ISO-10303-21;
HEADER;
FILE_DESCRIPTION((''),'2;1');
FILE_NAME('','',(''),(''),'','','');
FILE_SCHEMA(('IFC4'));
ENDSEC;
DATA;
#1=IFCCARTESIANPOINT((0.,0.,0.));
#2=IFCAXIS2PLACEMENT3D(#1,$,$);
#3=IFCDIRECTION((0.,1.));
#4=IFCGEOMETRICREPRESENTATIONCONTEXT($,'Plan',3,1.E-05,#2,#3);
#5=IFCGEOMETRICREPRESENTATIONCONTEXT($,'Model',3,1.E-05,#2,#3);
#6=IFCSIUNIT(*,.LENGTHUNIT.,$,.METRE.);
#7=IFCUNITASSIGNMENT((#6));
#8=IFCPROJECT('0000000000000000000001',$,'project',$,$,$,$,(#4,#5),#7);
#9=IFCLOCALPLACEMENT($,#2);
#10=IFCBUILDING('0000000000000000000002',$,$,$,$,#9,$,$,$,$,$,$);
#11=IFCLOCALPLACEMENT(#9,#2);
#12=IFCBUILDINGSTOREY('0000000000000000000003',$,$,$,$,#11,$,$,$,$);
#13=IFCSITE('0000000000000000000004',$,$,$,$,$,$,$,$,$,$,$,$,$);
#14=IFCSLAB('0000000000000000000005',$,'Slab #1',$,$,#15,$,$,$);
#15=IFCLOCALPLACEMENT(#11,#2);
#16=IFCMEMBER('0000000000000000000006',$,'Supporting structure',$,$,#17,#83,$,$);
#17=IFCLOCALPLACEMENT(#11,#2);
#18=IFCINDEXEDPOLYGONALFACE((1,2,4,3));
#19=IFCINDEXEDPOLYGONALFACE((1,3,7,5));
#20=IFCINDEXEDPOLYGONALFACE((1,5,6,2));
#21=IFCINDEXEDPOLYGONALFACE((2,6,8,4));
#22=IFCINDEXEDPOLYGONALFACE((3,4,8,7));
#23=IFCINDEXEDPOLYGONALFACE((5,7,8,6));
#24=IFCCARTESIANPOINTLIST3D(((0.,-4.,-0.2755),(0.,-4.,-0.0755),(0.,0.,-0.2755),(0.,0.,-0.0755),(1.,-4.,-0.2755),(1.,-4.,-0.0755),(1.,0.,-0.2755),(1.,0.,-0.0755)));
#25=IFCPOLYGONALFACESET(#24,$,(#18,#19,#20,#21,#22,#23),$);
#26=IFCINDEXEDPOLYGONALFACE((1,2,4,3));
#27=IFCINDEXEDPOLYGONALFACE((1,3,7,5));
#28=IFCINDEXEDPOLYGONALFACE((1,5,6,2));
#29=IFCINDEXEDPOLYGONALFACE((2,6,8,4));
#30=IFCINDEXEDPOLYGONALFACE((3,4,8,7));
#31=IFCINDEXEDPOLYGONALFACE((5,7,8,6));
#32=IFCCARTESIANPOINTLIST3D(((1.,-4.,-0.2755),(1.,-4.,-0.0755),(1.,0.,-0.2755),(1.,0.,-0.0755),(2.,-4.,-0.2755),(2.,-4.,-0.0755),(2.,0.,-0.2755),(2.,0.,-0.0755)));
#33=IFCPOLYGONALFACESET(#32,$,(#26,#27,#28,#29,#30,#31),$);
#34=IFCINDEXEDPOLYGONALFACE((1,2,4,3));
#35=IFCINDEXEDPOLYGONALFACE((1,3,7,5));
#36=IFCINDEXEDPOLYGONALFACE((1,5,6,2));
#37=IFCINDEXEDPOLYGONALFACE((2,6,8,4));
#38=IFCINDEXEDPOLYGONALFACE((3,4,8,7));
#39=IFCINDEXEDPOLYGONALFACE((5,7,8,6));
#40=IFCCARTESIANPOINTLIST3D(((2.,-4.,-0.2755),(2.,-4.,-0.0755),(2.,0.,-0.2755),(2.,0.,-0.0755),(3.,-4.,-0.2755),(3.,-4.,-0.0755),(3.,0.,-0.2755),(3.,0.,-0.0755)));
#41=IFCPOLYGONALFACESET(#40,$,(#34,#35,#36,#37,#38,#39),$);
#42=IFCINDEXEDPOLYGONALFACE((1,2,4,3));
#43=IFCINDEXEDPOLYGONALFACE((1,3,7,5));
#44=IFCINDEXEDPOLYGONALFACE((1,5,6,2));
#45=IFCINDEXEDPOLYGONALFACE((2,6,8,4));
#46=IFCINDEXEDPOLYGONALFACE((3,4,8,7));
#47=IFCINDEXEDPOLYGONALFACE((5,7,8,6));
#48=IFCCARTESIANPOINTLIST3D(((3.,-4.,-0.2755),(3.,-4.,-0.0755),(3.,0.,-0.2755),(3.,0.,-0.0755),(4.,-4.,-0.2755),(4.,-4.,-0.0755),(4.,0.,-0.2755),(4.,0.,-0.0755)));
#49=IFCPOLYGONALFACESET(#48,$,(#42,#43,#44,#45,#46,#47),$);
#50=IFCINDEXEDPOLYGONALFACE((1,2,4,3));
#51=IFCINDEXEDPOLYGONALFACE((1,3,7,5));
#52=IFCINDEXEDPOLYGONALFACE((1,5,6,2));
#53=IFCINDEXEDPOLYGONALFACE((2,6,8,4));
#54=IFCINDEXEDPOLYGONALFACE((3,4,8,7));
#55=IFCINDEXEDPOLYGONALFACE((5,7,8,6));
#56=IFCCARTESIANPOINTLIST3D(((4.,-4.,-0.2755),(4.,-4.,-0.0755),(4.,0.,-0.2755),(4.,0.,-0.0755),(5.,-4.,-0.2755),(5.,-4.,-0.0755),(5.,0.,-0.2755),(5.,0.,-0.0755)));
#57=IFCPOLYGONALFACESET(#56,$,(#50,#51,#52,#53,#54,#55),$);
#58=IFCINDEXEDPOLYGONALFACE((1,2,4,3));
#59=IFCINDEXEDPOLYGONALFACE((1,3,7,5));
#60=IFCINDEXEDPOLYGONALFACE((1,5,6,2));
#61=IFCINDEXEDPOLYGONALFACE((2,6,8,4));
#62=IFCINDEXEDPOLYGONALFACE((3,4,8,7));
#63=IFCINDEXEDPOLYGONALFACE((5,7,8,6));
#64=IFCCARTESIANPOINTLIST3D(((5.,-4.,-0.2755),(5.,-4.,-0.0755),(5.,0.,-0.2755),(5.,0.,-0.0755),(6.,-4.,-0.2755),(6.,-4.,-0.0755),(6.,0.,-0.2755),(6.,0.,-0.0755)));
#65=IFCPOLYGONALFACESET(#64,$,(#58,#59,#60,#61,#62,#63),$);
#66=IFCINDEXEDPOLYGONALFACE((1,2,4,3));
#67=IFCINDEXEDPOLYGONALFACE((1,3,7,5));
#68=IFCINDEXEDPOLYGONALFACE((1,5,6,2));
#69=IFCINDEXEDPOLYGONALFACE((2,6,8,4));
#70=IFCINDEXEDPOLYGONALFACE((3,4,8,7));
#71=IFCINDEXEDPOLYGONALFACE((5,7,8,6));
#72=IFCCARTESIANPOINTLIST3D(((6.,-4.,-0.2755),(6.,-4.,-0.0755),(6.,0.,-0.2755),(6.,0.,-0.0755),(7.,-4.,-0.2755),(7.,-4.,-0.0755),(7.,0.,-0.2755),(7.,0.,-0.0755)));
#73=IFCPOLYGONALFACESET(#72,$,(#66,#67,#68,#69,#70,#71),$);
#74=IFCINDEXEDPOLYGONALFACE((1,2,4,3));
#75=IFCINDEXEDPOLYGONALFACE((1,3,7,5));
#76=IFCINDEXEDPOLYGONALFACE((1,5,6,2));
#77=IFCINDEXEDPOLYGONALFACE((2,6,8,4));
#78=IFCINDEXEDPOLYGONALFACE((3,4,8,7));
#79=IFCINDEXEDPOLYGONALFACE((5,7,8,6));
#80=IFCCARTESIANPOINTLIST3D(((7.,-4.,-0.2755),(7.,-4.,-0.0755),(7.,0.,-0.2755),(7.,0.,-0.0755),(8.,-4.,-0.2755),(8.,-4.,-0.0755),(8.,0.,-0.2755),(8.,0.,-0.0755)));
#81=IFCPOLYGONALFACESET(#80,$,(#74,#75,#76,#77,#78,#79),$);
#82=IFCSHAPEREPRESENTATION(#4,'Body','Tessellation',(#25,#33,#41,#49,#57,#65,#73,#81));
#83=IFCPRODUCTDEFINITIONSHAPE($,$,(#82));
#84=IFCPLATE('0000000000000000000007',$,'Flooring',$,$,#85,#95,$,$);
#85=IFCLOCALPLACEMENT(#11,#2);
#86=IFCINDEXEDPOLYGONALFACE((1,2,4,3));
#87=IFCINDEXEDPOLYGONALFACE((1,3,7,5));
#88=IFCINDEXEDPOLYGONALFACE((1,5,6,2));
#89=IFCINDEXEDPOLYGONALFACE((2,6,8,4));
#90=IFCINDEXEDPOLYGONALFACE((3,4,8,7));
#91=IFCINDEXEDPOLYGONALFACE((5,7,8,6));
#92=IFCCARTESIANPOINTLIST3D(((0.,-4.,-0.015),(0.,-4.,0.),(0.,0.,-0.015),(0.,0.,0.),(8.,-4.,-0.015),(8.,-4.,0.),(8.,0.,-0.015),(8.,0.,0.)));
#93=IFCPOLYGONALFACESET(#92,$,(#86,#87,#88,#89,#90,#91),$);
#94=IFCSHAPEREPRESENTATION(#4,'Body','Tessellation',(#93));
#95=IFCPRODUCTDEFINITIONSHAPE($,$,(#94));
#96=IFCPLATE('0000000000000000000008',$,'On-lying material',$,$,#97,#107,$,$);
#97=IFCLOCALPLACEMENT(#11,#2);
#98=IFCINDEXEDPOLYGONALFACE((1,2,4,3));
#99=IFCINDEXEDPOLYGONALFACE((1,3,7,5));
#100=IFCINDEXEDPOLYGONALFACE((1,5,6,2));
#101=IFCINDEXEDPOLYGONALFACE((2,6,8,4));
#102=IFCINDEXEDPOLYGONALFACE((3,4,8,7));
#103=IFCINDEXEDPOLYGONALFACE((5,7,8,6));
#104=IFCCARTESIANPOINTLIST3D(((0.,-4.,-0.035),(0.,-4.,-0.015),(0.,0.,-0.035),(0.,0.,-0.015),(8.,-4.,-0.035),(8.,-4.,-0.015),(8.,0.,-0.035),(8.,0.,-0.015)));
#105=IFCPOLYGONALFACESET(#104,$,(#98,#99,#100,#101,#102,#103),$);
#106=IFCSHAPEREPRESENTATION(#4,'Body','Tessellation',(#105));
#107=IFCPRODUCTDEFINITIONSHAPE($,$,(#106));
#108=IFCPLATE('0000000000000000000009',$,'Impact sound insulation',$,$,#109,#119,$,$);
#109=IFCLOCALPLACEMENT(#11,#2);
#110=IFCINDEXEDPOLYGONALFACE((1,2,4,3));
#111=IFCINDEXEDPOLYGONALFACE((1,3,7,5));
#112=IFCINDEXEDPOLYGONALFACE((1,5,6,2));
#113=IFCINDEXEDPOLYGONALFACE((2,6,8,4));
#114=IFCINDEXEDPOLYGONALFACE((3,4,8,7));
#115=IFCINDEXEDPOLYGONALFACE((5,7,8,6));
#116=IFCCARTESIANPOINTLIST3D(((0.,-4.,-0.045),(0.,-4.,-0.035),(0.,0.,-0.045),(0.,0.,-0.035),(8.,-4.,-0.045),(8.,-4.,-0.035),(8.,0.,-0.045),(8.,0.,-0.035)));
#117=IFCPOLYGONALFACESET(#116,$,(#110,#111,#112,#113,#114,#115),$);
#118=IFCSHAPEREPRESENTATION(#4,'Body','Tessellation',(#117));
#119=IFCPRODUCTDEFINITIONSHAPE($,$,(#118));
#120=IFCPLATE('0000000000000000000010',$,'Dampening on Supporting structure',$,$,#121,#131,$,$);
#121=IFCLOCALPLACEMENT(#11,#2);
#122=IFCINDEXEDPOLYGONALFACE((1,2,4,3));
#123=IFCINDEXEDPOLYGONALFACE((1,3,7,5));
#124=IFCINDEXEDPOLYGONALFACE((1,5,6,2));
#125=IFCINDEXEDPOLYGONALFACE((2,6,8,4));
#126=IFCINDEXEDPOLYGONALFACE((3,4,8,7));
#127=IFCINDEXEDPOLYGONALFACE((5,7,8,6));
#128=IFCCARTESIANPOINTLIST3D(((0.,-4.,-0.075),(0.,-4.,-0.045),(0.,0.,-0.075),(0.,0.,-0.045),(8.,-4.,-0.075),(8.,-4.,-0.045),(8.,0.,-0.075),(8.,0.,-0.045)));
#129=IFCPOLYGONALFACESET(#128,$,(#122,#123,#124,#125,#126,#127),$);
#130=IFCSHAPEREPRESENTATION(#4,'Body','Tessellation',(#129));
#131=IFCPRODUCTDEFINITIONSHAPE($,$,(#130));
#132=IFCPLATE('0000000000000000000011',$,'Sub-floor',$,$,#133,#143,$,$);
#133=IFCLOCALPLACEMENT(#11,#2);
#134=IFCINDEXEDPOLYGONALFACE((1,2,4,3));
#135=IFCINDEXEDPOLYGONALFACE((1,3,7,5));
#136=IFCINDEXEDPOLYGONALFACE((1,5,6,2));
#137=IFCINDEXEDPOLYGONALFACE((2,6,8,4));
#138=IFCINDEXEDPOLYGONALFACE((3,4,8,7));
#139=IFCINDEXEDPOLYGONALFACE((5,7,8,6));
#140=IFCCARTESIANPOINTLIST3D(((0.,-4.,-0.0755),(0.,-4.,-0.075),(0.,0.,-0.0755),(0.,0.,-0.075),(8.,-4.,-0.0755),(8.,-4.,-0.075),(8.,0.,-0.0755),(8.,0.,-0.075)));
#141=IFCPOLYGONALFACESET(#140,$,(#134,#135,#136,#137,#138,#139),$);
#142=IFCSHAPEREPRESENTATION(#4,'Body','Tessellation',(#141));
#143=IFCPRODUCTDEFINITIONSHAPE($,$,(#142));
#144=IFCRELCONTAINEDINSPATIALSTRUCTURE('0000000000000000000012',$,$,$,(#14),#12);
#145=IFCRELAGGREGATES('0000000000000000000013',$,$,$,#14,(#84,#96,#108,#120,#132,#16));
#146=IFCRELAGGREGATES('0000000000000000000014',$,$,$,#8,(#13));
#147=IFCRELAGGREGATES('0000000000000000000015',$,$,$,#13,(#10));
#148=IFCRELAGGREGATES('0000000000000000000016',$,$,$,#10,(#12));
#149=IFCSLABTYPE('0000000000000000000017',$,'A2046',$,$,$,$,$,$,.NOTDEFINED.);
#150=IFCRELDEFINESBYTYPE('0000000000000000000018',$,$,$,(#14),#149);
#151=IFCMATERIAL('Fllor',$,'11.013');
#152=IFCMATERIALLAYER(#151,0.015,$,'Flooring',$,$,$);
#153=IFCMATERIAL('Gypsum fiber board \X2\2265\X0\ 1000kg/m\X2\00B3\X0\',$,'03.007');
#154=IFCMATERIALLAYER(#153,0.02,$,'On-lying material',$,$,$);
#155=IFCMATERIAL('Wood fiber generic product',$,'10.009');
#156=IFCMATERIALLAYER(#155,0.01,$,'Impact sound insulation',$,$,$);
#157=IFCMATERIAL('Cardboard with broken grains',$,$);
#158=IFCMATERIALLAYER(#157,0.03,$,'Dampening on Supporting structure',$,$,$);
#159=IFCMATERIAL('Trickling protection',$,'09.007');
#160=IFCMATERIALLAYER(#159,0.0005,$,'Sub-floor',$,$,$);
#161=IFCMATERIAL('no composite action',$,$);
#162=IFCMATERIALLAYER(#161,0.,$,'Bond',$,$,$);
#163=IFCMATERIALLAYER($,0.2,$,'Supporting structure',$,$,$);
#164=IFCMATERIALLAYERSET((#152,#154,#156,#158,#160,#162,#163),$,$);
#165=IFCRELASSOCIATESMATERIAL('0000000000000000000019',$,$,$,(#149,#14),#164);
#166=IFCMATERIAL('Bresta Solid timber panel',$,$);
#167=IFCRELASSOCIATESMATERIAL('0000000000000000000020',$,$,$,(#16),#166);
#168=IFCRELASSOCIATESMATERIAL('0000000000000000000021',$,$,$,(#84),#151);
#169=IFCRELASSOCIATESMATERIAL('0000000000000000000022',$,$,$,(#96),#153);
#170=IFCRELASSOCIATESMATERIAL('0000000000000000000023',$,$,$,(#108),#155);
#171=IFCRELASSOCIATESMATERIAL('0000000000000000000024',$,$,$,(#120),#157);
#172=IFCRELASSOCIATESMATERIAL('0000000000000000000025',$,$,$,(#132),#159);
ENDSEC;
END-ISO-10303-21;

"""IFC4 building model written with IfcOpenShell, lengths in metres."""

from ifc_helpers import new_model, si_unit, direction, frame, frame_2d, origin, origin_with_axes, place, context, project, spatial, rectangle, extrude, material, layer, layer_set, type_object, element, aggregate, save


model = new_model("IFC4")

# Units and contexts
plan_context = context("Plan", 3, precision=1e-05, world=origin(), true_north=direction((0.0, 1.0)))
model_context = context("Model", 3, precision=1e-05, world=origin(), true_north=direction((0.0, 1.0)))
ifc_project = project(units=[si_unit("LENGTHUNIT", "METRE")], contexts=[plan_context, model_context])

# Site, building, storey
site = spatial("IfcSite", under=ifc_project)
building_placement = place(None, origin())
building = spatial("IfcBuilding", under=site, at=building_placement)
storey_placement = place(building_placement, origin())
storey = spatial("IfcBuildingStorey", under=building, at=storey_placement)

# Slab, member, plates
ifc_material_1 = material(Name="Fllor", Category="11.013")
ifc_layer_1 = layer(ifc_material_1, 0.015, Name="Flooring")
ifc_material_2 = material(Name="Gypsum fiber board ≥ 1000kg/m³", Category="03.007")
ifc_layer_2 = layer(ifc_material_2, 0.02, Name="On-lying material")
ifc_material_3 = material(Name="Wood fiber generic product", Category="10.009")
ifc_layer_3 = layer(ifc_material_3, 0.01, Name="Impact sound insulation")
ifc_material_4 = material(Name="Cardboard with broken grains")
ifc_layer_4 = layer(ifc_material_4, 0.03, Name="Dampening on Supporting structure")
ifc_material_5 = material(Name="Trickling protection", Category="09.007")
ifc_layer_5 = layer(ifc_material_5, 0.0005, Name="Sub-floor")
ifc_material_6 = material(Name="no composite action")
ifc_layer_6 = layer(ifc_material_6, 0.0, Name="Bond")
ifc_layer_7 = layer(None, 0.2, Name="Supporting structure")
ifc_layer_set = layer_set([ifc_layer_1, ifc_layer_2, ifc_layer_3, ifc_layer_4, ifc_layer_5, ifc_layer_6, ifc_layer_7])
slab_type = type_object("IfcSlabType", Name="A2046", PredefinedType="NOTDEFINED", material=ifc_layer_set)
slab_placement = place(None, frame((0.0, 0.0, 0.0), z_axis=(0.0, 0.0, -1.0), x_axis=(1.0, 0.0, 0.0)))
slab = element("IfcSlab", 1, at=slab_placement, inside=storey, type_object=slab_type, material=ifc_layer_set, Name="Slab #1")
ifc_material_7 = material(Name="Bresta Solid timber panel")
member_placement = place(slab_placement, origin())
member = element("IfcMember", 2, at=member_placement, material=ifc_material_7, Name="Supporting structure", context=plan_context, shape_type="SweptSolid", body=[
    extrude(rectangle(XDim=1.0, YDim=0.2, at=frame_2d((0.5, 0.1), x_axis=(1.0, 0.0))), frame((0.0, 4.0, 0.0755), z_axis=(0.0, -1.0, 0.0), x_axis=(1.0, 0.0, 0.0)), (0.0, 0.0, 1.0), 4.0),
    extrude(rectangle(XDim=1.0, YDim=0.2, at=frame_2d((0.5, 0.1), x_axis=(1.0, 0.0))), frame((1.0, 4.0, 0.0755), z_axis=(0.0, -1.0, 0.0), x_axis=(1.0, 0.0, 0.0)), (0.0, 0.0, 1.0), 4.0),
    extrude(rectangle(XDim=1.0, YDim=0.2, at=frame_2d((0.5, 0.1), x_axis=(1.0, 0.0))), frame((2.0, 4.0, 0.0755), z_axis=(0.0, -1.0, 0.0), x_axis=(1.0, 0.0, 0.0)), (0.0, 0.0, 1.0), 4.0),
    extrude(rectangle(XDim=1.0, YDim=0.2, at=frame_2d((0.5, 0.1), x_axis=(1.0, 0.0))), frame((3.0, 4.0, 0.0755), z_axis=(0.0, -1.0, 0.0), x_axis=(1.0, 0.0, 0.0)), (0.0, 0.0, 1.0), 4.0),
    extrude(rectangle(XDim=1.0, YDim=0.2, at=frame_2d((0.5, 0.1), x_axis=(1.0, 0.0))), frame((4.0, 4.0, 0.0755), z_axis=(0.0, -1.0, 0.0), x_axis=(1.0, 0.0, 0.0)), (0.0, 0.0, 1.0), 4.0),
    extrude(rectangle(XDim=1.0, YDim=0.2, at=frame_2d((0.5, 0.1), x_axis=(1.0, 0.0))), frame((5.0, 4.0, 0.0755), z_axis=(0.0, -1.0, 0.0), x_axis=(1.0, 0.0, 0.0)), (0.0, 0.0, 1.0), 4.0),
    extrude(rectangle(XDim=1.0, YDim=0.2, at=frame_2d((0.5, 0.1), x_axis=(1.0, 0.0))), frame((6.0, 4.0, 0.0755), z_axis=(0.0, -1.0, 0.0), x_axis=(1.0, 0.0, 0.0)), (0.0, 0.0, 1.0), 4.0),
    extrude(rectangle(XDim=1.0, YDim=0.2, at=frame_2d((0.5, 0.1), x_axis=(1.0, 0.0))), frame((7.0, 4.0, 0.0755), z_axis=(0.0, -1.0, 0.0), x_axis=(1.0, 0.0, 0.0)), (0.0, 0.0, 1.0), 4.0),
])
plate_1_placement = place(slab_placement, origin())
plate_1 = element("IfcPlate", 3, at=plate_1_placement, material=ifc_material_1, Name="Flooring", context=plan_context, shape_type="SweptSolid", body=[
    extrude(rectangle(XDim=8.0, YDim=4.0, at=frame_2d((4.0, 2.0), x_axis=(1.0, 0.0))), origin_with_axes(), (0.0, 0.0, 1.0), 0.015),
])
plate_2_placement = place(slab_placement, origin())
plate_2 = element("IfcPlate", 4, at=plate_2_placement, material=ifc_material_2, Name="On-lying material", context=plan_context, shape_type="SweptSolid", body=[
    extrude(rectangle(XDim=8.0, YDim=4.0, at=frame_2d((4.0, 2.0), x_axis=(1.0, 0.0))), frame((0.0, 0.0, 0.015), z_axis=(0.0, 0.0, 1.0), x_axis=(1.0, 0.0, 0.0)), (0.0, 0.0, 1.0), 0.02),
])
plate_3_placement = place(slab_placement, origin())
plate_3 = element("IfcPlate", 5, at=plate_3_placement, material=ifc_material_3, Name="Impact sound insulation", context=plan_context, shape_type="SweptSolid", body=[
    extrude(rectangle(XDim=8.0, YDim=4.0, at=frame_2d((4.0, 2.0), x_axis=(1.0, 0.0))), frame((0.0, 0.0, 0.035), z_axis=(0.0, 0.0, 1.0), x_axis=(1.0, 0.0, 0.0)), (0.0, 0.0, 1.0), 0.01),
])
plate_4_placement = place(slab_placement, origin())
plate_4 = element("IfcPlate", 6, at=plate_4_placement, material=ifc_material_4, Name="Dampening on Supporting structure", context=plan_context, shape_type="SweptSolid", body=[
    extrude(rectangle(XDim=8.0, YDim=4.0, at=frame_2d((4.0, 2.0), x_axis=(1.0, 0.0))), frame((0.0, 0.0, 0.045), z_axis=(0.0, 0.0, 1.0), x_axis=(1.0, 0.0, 0.0)), (0.0, 0.0, 1.0), 0.03),
])
plate_5_placement = place(slab_placement, origin())
plate_5 = element("IfcPlate", 7, at=plate_5_placement, material=ifc_material_5, Name="Sub-floor", context=plan_context, shape_type="SweptSolid", body=[
    extrude(rectangle(XDim=8.0, YDim=4.0, at=frame_2d((4.0, 2.0), x_axis=(1.0, 0.0))), frame((0.0, 0.0, 0.075), z_axis=(0.0, 0.0, 1.0), x_axis=(1.0, 0.0, 0.0)), (0.0, 0.0, 1.0), 0.0005),
])
aggregate(slab, [plate_1, plate_2, plate_3, plate_4, plate_5, member])

save(model, "model.ifc")
